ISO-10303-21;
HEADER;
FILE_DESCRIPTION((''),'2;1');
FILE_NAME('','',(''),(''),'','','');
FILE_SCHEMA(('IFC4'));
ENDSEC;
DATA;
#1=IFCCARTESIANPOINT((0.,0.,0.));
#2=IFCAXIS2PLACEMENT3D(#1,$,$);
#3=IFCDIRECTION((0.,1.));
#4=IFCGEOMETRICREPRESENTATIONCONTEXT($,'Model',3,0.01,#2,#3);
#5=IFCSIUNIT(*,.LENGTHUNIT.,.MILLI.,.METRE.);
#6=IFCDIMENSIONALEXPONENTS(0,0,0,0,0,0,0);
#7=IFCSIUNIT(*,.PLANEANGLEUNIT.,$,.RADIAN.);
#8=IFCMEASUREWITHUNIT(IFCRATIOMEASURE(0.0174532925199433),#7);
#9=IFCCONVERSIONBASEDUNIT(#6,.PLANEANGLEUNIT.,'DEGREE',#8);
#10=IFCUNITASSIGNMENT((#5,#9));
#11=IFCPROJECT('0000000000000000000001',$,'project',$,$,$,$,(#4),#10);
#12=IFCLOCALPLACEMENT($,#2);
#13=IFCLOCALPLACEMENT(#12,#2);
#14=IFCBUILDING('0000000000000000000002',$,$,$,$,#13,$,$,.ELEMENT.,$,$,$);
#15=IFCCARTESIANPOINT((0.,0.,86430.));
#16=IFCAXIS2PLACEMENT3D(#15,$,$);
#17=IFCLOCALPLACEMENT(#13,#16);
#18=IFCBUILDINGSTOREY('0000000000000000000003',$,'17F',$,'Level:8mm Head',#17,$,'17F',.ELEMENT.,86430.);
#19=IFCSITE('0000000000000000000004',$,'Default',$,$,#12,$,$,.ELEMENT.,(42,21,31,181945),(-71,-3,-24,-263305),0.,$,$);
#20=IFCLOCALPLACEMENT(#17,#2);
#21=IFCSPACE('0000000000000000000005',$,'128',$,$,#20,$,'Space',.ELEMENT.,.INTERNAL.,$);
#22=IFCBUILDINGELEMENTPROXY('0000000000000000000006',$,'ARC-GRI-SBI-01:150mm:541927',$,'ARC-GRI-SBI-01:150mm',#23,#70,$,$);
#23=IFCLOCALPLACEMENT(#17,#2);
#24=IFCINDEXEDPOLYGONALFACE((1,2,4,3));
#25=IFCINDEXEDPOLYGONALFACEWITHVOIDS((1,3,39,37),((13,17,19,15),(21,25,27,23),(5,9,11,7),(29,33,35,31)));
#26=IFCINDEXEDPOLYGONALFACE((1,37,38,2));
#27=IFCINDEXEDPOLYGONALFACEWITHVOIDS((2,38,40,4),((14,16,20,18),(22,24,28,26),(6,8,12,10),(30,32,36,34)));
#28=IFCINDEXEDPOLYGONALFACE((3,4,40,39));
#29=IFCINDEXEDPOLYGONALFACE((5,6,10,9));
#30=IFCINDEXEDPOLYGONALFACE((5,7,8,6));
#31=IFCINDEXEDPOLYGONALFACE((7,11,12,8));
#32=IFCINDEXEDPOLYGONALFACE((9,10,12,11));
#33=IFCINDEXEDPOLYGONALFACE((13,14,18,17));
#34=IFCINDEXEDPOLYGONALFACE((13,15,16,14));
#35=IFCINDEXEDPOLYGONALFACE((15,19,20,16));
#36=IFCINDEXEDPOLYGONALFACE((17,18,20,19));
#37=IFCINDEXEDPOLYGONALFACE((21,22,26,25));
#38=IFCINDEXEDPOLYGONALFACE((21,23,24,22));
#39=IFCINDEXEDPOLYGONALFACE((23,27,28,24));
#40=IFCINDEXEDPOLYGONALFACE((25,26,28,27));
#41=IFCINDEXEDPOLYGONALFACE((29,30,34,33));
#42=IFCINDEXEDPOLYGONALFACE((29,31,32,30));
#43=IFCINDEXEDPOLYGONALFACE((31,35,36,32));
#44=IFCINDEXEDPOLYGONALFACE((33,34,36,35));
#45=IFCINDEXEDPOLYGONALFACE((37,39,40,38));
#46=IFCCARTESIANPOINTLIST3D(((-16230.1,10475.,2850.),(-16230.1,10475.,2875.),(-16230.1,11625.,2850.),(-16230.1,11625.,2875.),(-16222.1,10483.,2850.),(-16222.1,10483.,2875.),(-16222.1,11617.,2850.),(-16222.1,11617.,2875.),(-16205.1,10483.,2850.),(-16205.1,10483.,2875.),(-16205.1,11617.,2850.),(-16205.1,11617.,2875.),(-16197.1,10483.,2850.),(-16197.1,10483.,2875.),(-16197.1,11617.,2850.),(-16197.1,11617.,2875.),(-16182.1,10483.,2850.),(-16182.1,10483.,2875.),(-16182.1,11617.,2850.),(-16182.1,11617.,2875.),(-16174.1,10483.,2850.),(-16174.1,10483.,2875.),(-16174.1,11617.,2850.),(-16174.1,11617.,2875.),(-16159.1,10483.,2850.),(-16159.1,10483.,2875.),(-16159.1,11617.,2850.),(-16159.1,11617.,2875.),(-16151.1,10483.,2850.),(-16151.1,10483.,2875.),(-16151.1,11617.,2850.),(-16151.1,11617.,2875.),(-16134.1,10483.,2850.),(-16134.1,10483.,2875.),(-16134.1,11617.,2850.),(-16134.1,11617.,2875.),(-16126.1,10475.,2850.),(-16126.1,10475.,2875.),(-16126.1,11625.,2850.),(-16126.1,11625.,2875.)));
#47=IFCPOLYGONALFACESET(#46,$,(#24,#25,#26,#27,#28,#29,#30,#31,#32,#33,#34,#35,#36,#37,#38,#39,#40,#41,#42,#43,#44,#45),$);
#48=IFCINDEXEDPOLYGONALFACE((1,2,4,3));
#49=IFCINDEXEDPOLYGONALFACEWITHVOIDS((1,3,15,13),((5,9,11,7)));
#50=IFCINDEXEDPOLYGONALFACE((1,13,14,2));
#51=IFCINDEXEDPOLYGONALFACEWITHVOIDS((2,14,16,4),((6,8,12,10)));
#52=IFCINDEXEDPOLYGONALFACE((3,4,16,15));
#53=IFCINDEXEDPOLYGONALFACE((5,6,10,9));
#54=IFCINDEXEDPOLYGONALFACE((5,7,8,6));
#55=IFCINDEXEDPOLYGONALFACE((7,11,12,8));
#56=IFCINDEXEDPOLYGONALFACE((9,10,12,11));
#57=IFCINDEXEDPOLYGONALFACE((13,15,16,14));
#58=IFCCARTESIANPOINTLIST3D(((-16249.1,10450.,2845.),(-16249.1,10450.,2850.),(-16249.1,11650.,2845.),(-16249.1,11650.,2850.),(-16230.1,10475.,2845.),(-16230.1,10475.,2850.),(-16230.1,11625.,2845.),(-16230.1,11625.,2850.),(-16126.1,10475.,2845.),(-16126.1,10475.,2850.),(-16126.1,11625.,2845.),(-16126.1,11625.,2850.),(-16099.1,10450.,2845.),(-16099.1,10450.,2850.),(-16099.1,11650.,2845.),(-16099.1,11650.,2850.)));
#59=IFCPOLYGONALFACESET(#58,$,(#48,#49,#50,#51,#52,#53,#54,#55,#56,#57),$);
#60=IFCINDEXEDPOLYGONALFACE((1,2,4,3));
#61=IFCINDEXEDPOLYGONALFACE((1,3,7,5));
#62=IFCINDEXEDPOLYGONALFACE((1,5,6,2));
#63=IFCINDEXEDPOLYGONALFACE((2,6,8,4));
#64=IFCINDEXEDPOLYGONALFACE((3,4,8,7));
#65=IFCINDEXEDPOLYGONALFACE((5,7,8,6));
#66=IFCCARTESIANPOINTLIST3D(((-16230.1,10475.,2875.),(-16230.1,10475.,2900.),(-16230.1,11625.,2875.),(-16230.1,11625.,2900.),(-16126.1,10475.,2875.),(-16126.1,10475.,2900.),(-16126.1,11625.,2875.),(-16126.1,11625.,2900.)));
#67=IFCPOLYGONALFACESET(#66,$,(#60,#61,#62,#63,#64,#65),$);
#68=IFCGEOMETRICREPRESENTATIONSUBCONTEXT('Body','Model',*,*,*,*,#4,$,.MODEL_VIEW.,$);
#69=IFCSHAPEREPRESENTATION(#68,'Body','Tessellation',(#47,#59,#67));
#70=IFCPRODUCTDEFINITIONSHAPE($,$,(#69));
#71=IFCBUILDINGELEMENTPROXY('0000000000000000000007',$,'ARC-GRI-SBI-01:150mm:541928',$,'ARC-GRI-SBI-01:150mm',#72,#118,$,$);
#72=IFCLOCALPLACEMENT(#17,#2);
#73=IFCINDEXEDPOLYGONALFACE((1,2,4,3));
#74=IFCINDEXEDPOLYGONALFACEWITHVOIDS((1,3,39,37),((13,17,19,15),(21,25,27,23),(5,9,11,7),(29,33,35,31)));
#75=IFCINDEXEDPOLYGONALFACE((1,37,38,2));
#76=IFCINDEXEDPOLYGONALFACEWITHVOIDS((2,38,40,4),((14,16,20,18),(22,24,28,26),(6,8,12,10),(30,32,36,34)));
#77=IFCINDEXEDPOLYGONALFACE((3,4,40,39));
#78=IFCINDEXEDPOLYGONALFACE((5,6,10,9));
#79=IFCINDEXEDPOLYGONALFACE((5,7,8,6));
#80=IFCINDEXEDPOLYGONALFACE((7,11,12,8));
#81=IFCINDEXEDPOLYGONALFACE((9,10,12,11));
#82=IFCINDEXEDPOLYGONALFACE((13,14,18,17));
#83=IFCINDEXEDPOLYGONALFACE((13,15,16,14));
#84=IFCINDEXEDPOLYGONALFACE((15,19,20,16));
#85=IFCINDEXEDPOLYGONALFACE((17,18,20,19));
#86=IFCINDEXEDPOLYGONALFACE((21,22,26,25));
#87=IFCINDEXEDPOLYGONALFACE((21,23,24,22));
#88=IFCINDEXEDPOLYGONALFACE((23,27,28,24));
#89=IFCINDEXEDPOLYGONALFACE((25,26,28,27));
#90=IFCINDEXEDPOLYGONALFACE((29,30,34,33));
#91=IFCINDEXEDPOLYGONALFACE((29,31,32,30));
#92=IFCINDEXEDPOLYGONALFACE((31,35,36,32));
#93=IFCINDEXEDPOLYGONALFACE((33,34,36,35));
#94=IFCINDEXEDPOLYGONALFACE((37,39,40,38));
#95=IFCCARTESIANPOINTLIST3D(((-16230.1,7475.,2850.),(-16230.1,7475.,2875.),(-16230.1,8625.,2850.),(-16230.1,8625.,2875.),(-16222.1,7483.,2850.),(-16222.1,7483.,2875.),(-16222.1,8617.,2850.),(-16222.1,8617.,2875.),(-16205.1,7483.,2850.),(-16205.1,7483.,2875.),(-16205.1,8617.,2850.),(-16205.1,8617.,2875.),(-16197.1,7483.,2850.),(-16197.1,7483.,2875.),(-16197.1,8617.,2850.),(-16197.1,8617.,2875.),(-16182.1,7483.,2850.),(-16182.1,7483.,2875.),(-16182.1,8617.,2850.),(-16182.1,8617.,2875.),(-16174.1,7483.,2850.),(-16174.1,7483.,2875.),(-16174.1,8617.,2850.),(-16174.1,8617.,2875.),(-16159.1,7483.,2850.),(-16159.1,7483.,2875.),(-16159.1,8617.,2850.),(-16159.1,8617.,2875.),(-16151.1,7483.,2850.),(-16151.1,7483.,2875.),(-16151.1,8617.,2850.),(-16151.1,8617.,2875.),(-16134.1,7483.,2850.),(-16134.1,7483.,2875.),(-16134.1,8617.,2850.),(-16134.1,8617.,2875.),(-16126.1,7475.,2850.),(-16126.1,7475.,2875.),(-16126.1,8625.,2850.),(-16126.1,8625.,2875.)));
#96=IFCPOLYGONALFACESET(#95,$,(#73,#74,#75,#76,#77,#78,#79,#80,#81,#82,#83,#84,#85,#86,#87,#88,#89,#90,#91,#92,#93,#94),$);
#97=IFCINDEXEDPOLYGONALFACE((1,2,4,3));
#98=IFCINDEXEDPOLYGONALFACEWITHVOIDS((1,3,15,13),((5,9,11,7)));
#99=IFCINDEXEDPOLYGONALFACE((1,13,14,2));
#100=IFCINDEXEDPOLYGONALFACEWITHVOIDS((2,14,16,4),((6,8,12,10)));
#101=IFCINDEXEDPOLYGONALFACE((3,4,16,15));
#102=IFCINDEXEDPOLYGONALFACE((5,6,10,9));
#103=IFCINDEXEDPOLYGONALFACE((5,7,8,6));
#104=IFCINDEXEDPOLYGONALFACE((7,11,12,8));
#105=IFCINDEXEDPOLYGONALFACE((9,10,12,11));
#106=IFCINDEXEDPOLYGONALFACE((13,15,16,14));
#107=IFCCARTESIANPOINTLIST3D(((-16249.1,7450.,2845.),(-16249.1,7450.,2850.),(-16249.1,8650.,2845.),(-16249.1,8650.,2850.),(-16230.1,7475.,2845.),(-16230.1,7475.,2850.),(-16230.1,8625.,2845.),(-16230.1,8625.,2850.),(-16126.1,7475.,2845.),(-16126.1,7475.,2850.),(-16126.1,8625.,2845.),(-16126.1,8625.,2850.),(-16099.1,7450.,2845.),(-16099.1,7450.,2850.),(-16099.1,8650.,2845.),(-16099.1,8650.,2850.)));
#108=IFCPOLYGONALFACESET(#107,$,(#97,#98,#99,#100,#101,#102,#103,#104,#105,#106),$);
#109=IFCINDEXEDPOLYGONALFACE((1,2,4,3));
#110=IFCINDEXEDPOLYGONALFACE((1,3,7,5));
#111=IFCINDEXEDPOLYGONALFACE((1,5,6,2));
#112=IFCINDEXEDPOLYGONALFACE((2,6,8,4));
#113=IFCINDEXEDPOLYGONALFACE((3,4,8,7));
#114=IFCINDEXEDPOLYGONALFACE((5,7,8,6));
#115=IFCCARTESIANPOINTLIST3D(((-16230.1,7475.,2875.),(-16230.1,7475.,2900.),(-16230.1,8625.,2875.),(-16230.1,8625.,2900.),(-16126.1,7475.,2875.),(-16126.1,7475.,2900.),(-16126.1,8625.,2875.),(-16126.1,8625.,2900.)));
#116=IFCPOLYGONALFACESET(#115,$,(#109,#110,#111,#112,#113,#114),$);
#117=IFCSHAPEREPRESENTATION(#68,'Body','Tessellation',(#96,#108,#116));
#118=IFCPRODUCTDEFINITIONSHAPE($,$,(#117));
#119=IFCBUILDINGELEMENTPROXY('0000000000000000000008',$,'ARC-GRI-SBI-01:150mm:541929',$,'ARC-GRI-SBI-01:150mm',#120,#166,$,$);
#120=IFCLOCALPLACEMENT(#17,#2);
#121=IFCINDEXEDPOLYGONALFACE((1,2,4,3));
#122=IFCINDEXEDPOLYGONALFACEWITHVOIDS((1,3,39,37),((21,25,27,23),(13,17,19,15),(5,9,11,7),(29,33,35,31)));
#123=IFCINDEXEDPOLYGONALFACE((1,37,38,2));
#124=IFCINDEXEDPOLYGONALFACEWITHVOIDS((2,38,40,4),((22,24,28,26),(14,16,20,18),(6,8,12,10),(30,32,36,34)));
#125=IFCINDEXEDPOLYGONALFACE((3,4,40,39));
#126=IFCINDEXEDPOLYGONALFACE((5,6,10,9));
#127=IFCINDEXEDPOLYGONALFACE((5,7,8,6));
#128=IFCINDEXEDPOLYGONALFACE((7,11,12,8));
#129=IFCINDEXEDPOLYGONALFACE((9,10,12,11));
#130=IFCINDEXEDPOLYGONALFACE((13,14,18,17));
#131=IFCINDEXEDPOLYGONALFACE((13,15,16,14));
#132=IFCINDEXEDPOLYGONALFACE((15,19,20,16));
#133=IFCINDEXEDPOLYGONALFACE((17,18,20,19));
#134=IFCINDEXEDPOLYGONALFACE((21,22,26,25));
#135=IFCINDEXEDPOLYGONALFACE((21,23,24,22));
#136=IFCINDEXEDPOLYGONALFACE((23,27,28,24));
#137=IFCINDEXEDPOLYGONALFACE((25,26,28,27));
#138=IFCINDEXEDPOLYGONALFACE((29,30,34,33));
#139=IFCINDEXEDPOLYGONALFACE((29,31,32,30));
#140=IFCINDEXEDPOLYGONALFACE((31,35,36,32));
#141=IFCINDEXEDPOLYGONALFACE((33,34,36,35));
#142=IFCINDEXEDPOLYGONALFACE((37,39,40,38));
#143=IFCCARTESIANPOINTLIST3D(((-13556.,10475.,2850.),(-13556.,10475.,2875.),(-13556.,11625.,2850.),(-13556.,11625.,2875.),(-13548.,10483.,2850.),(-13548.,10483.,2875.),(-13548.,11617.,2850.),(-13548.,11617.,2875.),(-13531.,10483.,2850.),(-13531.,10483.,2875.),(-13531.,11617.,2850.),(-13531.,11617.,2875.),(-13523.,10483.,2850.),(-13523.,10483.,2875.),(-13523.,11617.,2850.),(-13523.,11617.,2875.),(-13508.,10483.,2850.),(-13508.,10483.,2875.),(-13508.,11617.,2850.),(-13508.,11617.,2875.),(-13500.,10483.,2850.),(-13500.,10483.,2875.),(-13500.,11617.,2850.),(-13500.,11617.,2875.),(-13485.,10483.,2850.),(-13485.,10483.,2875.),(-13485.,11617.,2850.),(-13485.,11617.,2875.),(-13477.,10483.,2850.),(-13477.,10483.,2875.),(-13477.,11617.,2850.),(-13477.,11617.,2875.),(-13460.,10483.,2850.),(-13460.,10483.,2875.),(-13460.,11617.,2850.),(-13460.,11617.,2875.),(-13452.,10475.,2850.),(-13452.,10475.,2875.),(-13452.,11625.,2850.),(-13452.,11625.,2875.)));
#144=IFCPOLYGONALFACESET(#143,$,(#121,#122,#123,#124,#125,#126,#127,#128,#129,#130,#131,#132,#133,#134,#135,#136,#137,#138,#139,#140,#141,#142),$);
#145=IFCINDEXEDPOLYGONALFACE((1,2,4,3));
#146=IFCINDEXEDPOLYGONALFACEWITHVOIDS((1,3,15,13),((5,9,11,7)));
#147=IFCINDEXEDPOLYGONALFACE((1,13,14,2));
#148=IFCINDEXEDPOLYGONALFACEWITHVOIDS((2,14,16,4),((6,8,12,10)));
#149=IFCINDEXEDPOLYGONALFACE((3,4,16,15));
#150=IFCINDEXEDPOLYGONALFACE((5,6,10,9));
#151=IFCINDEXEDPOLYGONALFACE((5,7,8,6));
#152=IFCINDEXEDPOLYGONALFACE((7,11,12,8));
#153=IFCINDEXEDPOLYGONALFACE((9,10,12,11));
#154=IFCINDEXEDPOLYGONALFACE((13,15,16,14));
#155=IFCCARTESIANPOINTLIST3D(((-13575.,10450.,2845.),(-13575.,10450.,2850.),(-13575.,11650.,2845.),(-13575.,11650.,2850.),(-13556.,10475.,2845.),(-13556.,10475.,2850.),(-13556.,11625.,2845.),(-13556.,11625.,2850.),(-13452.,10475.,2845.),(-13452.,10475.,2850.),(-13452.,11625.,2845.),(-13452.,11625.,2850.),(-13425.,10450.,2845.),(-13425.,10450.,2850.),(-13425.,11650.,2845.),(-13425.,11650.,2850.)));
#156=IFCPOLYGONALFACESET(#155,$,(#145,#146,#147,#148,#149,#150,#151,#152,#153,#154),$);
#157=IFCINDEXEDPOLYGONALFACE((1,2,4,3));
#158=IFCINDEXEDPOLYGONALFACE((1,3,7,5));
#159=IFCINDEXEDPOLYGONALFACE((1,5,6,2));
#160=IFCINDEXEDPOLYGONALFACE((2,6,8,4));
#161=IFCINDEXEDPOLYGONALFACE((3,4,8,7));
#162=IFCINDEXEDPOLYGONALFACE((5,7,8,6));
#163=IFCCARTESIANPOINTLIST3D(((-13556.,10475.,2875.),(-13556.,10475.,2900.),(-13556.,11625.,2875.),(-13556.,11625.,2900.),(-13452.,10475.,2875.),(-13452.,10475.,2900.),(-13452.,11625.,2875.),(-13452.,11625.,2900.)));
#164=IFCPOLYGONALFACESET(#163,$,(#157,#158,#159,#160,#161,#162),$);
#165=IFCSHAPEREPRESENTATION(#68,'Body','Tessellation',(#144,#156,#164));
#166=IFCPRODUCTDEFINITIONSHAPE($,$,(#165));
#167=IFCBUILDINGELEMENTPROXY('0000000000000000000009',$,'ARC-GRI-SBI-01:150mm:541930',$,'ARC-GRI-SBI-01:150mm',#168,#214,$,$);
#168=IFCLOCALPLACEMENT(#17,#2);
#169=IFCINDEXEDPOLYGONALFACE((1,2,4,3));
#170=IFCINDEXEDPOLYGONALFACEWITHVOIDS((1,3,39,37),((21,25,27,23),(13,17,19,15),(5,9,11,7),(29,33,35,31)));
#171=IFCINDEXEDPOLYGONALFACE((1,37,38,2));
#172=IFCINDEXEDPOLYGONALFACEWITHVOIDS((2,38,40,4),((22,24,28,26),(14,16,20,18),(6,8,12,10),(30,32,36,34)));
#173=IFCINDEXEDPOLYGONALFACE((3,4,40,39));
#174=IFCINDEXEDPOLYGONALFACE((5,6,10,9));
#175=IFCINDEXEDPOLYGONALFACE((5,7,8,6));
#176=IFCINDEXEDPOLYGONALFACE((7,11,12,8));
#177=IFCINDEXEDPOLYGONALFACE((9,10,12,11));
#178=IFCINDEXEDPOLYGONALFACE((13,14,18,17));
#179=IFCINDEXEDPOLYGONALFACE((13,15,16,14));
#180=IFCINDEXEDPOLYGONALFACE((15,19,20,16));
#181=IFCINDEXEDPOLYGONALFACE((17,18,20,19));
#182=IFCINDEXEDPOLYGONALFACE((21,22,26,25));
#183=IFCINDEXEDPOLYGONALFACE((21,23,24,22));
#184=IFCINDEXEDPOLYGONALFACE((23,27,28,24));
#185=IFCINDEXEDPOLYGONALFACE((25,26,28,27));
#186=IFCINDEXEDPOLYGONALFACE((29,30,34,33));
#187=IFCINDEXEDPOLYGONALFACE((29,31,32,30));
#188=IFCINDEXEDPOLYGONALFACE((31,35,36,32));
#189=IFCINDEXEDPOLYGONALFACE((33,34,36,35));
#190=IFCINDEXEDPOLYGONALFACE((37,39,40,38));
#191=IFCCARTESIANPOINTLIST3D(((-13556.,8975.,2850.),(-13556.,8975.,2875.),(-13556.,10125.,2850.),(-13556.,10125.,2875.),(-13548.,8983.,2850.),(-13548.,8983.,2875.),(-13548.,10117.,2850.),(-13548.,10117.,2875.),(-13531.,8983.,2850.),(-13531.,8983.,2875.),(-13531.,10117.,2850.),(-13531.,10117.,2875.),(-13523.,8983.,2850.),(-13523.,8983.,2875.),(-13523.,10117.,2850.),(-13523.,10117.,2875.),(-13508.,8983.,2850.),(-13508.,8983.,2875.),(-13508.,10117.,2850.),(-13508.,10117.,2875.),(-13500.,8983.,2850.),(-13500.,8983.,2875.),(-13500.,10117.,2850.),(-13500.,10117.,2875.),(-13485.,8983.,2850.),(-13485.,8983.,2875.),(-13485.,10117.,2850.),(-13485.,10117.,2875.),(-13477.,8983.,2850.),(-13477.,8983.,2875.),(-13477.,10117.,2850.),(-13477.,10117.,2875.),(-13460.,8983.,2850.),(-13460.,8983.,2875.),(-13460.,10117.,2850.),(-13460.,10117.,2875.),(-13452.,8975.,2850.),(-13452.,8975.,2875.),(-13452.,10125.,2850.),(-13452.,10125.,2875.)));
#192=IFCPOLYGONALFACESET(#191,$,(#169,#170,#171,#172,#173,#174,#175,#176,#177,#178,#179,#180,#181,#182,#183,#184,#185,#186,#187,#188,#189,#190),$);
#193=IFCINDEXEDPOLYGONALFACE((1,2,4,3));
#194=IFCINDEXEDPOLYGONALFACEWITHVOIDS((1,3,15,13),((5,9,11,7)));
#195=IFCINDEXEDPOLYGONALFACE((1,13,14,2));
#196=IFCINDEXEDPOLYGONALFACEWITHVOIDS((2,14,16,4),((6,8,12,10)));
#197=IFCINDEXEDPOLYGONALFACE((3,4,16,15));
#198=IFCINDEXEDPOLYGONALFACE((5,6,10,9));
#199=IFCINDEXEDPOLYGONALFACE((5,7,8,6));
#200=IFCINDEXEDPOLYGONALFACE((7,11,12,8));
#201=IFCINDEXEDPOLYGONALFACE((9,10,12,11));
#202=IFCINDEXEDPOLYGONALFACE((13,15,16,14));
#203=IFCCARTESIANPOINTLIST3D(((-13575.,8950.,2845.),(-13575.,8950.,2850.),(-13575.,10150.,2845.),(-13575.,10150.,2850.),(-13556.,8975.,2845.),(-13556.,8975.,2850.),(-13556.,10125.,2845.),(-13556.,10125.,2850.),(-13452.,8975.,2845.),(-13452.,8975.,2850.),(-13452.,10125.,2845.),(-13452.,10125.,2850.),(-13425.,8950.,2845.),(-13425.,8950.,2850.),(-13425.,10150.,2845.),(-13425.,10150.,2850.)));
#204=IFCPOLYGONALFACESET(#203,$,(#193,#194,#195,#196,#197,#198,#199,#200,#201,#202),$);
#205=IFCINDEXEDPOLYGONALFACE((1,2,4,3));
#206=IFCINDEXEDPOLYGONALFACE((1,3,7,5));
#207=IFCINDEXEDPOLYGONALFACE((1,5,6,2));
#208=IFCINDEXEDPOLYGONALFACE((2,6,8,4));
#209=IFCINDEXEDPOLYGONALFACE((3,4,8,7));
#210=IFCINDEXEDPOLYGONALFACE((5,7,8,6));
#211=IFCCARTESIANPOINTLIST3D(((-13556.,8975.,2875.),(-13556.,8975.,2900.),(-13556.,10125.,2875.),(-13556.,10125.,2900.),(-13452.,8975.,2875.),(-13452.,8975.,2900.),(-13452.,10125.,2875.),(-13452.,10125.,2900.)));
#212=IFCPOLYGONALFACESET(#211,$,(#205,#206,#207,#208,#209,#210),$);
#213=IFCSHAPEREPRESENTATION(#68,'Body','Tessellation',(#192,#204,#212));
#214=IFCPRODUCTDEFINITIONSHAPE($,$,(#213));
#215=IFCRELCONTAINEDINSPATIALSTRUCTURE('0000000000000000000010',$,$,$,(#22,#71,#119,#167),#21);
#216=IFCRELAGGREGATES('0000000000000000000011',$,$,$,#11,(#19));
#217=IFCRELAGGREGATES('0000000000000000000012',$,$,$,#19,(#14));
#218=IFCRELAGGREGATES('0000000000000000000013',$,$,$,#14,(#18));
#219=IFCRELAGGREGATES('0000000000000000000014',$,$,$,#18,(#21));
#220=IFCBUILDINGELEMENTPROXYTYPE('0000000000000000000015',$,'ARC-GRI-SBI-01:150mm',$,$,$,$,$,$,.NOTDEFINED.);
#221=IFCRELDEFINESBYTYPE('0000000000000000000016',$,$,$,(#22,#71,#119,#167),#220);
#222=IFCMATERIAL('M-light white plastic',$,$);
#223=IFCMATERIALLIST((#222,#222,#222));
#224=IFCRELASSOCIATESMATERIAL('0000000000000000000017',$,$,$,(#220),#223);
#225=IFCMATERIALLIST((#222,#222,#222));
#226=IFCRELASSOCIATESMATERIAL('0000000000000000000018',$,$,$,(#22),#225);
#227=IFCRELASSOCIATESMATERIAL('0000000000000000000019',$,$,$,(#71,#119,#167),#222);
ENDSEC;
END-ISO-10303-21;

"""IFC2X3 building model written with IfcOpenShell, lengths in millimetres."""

from ifc_helpers import new_model, entity, si_unit, converted_unit, direction, frame, origin, origin_2d_with_axis, place, context, subcontext, project, spatial, polyline, rectangle, outline, extrude, source, transform, mapped, material, material_list, type_object, type_shapes, element, save


model = new_model("IFC2X3")

# Units and contexts
model_context = context("Model", 3, precision=0.01, world=origin(), true_north=direction((0.0, 1.0)))
body_context = subcontext(model_context, "Body", "Model", "MODEL_VIEW")
ifc_project = project(units=[si_unit("LENGTHUNIT", "METRE", prefix="MILLI"), converted_unit("PLANEANGLEUNIT", "DEGREE", entity("IfcRatioMeasure", 0.0174532925199433), si_unit("PLANEANGLEUNIT", "RADIAN"), dimensions=[0, 0, 0, 0, 0, 0, 0])], contexts=[model_context])

# Site, building, storey, space
site_placement = place(None, origin())
site = spatial("IfcSite", under=ifc_project, at=site_placement, Name="Default", CompositionType="ELEMENT", RefLatitude=(42, 21, 31, 181945), RefLongitude=(-71, -3, -24, -263305), RefElevation=0.0)
building_placement = place(site_placement, origin())
building = spatial("IfcBuilding", under=site, at=building_placement, CompositionType="ELEMENT")
storey_placement = place(building_placement, frame((0.0, 0.0, 86430.0)))
storey = spatial("IfcBuildingStorey", under=building, at=storey_placement, Name="17F", ObjectType="Level:8mm Head", LongName="17F", CompositionType="ELEMENT", Elevation=86430.0)
space_placement = place(storey_placement, origin())
space = spatial("IfcSpace", under=storey, at=space_placement, Name="128", LongName="Space", CompositionType="ELEMENT", InteriorOrExteriorSpace="INTERNAL")

# Shared definitions
ifc_material_1 = material(Name="M-light white plastic")

# Building element proxies
ifc_material_list_1 = material_list([ifc_material_1, ifc_material_1, ifc_material_1])
ifc_material_list_2 = material_list([ifc_material_1, ifc_material_1, ifc_material_1])
building_element_proxy_type = type_object("IfcBuildingElementProxyType", Name="ARC-GRI-SBI-01:150mm", PredefinedType="NOTDEFINED", material=ifc_material_list_2)
shared_shape_1 = source(origin(), body_context, "Body", "SweptSolid", [
    extrude(outline(polyline([(-575.0, -52.0), (575.0, -52.0), (575.0, 52.0), (-575.0, 52.0), (-575.0, -52.0)]), holes=[polyline([(-567.0, -44.0), (-567.0, -27.0), (567.0, -27.0), (567.0, -44.0), (-567.0, -44.0)]), polyline([(567.0, -4.0), (567.0, -19.0), (-567.0, -19.0), (-567.0, -4.0), (567.0, -4.0)]), polyline([(-567.0, 44.0), (567.0, 44.0), (567.0, 27.0), (-567.0, 27.0), (-567.0, 44.0)]), polyline([(567.0, 4.0), (-567.0, 4.0), (-567.0, 19.0), (567.0, 19.0), (567.0, 4.0)])]), frame((425.0, 4.0, 4000.0), z_axis=(0.0, 0.0, 1.0), x_axis=(-1.0, 0.0, 0.0)), (0.0, 0.0, 1.0), 25.0),
    extrude(outline(polyline([(-600.0, -75.0), (600.0, -75.0), (600.0, 75.0), (-600.0, 75.0), (-600.0, -75.0)]), holes=[polyline([(-575.0, -56.0), (-575.0, 48.0), (575.0, 48.0), (575.0, -56.0), (-575.0, -56.0)])]), frame((425.0, 0.0, 3995.0), z_axis=(0.0, 0.0, 1.0), x_axis=(-1.0, 0.0, 0.0)), (0.0, 0.0, 1.0), 5.0),
    extrude(rectangle(XDim=1150.0, YDim=104.0, at=origin_2d_with_axis()), frame((425.0, 4.0, 4025.0), z_axis=(0.0, 0.0, 1.0), x_axis=(-1.0, 0.0, 0.0)), (0.0, 0.0, 1.0), 25.0),
])
type_shapes(building_element_proxy_type, [shared_shape_1])
proxy_placement = place(space_placement, frame((-16174.1, 10625.0, -1150.0), z_axis=(0.0, 0.0, 1.0), x_axis=(0.0, 1.0, 0.0)))
element("IfcBuildingElementProxy", 1, at=proxy_placement, inside=space, type_object=building_element_proxy_type, material=ifc_material_list_1, Name="ARC-GRI-SBI-01:150mm:541927", ObjectType="ARC-GRI-SBI-01:150mm", context=body_context, shape_type="MappedRepresentation", body=[
    mapped(shared_shape_1, transform((0.0, 0.0, 0.0), scale=1.0)),
])
for number, where, z_axis, x_axis, name in (
    (2, (-16174.1, 7625.0, -1150.0), (0.0, 0.0, 1.0), (0.0, 1.0, 0.0), "ARC-GRI-SBI-01:150mm:541928"),
    (3, (-13500.0, 10625.0, -1150.0), (0.0, 0.0, 1.0), (0.0, 1.0, 0.0), "ARC-GRI-SBI-01:150mm:541929"),
    (4, (-13500.0, 9125.0, -1150.0), (0.0, 0.0, 1.0), (0.0, 1.0, 0.0), "ARC-GRI-SBI-01:150mm:541930"),
):
    element("IfcBuildingElementProxy", number, at=place(space_placement, frame(where, z_axis=z_axis, x_axis=x_axis)), inside=space, type_object=building_element_proxy_type, material=ifc_material_1, Name=name, ObjectType="ARC-GRI-SBI-01:150mm", context=body_context, shape_type="MappedRepresentation", body=[
        mapped(shared_shape_1, transform((0.0, 0.0, 0.0), scale=1.0)),
    ])

save(model, "model.ifc")
